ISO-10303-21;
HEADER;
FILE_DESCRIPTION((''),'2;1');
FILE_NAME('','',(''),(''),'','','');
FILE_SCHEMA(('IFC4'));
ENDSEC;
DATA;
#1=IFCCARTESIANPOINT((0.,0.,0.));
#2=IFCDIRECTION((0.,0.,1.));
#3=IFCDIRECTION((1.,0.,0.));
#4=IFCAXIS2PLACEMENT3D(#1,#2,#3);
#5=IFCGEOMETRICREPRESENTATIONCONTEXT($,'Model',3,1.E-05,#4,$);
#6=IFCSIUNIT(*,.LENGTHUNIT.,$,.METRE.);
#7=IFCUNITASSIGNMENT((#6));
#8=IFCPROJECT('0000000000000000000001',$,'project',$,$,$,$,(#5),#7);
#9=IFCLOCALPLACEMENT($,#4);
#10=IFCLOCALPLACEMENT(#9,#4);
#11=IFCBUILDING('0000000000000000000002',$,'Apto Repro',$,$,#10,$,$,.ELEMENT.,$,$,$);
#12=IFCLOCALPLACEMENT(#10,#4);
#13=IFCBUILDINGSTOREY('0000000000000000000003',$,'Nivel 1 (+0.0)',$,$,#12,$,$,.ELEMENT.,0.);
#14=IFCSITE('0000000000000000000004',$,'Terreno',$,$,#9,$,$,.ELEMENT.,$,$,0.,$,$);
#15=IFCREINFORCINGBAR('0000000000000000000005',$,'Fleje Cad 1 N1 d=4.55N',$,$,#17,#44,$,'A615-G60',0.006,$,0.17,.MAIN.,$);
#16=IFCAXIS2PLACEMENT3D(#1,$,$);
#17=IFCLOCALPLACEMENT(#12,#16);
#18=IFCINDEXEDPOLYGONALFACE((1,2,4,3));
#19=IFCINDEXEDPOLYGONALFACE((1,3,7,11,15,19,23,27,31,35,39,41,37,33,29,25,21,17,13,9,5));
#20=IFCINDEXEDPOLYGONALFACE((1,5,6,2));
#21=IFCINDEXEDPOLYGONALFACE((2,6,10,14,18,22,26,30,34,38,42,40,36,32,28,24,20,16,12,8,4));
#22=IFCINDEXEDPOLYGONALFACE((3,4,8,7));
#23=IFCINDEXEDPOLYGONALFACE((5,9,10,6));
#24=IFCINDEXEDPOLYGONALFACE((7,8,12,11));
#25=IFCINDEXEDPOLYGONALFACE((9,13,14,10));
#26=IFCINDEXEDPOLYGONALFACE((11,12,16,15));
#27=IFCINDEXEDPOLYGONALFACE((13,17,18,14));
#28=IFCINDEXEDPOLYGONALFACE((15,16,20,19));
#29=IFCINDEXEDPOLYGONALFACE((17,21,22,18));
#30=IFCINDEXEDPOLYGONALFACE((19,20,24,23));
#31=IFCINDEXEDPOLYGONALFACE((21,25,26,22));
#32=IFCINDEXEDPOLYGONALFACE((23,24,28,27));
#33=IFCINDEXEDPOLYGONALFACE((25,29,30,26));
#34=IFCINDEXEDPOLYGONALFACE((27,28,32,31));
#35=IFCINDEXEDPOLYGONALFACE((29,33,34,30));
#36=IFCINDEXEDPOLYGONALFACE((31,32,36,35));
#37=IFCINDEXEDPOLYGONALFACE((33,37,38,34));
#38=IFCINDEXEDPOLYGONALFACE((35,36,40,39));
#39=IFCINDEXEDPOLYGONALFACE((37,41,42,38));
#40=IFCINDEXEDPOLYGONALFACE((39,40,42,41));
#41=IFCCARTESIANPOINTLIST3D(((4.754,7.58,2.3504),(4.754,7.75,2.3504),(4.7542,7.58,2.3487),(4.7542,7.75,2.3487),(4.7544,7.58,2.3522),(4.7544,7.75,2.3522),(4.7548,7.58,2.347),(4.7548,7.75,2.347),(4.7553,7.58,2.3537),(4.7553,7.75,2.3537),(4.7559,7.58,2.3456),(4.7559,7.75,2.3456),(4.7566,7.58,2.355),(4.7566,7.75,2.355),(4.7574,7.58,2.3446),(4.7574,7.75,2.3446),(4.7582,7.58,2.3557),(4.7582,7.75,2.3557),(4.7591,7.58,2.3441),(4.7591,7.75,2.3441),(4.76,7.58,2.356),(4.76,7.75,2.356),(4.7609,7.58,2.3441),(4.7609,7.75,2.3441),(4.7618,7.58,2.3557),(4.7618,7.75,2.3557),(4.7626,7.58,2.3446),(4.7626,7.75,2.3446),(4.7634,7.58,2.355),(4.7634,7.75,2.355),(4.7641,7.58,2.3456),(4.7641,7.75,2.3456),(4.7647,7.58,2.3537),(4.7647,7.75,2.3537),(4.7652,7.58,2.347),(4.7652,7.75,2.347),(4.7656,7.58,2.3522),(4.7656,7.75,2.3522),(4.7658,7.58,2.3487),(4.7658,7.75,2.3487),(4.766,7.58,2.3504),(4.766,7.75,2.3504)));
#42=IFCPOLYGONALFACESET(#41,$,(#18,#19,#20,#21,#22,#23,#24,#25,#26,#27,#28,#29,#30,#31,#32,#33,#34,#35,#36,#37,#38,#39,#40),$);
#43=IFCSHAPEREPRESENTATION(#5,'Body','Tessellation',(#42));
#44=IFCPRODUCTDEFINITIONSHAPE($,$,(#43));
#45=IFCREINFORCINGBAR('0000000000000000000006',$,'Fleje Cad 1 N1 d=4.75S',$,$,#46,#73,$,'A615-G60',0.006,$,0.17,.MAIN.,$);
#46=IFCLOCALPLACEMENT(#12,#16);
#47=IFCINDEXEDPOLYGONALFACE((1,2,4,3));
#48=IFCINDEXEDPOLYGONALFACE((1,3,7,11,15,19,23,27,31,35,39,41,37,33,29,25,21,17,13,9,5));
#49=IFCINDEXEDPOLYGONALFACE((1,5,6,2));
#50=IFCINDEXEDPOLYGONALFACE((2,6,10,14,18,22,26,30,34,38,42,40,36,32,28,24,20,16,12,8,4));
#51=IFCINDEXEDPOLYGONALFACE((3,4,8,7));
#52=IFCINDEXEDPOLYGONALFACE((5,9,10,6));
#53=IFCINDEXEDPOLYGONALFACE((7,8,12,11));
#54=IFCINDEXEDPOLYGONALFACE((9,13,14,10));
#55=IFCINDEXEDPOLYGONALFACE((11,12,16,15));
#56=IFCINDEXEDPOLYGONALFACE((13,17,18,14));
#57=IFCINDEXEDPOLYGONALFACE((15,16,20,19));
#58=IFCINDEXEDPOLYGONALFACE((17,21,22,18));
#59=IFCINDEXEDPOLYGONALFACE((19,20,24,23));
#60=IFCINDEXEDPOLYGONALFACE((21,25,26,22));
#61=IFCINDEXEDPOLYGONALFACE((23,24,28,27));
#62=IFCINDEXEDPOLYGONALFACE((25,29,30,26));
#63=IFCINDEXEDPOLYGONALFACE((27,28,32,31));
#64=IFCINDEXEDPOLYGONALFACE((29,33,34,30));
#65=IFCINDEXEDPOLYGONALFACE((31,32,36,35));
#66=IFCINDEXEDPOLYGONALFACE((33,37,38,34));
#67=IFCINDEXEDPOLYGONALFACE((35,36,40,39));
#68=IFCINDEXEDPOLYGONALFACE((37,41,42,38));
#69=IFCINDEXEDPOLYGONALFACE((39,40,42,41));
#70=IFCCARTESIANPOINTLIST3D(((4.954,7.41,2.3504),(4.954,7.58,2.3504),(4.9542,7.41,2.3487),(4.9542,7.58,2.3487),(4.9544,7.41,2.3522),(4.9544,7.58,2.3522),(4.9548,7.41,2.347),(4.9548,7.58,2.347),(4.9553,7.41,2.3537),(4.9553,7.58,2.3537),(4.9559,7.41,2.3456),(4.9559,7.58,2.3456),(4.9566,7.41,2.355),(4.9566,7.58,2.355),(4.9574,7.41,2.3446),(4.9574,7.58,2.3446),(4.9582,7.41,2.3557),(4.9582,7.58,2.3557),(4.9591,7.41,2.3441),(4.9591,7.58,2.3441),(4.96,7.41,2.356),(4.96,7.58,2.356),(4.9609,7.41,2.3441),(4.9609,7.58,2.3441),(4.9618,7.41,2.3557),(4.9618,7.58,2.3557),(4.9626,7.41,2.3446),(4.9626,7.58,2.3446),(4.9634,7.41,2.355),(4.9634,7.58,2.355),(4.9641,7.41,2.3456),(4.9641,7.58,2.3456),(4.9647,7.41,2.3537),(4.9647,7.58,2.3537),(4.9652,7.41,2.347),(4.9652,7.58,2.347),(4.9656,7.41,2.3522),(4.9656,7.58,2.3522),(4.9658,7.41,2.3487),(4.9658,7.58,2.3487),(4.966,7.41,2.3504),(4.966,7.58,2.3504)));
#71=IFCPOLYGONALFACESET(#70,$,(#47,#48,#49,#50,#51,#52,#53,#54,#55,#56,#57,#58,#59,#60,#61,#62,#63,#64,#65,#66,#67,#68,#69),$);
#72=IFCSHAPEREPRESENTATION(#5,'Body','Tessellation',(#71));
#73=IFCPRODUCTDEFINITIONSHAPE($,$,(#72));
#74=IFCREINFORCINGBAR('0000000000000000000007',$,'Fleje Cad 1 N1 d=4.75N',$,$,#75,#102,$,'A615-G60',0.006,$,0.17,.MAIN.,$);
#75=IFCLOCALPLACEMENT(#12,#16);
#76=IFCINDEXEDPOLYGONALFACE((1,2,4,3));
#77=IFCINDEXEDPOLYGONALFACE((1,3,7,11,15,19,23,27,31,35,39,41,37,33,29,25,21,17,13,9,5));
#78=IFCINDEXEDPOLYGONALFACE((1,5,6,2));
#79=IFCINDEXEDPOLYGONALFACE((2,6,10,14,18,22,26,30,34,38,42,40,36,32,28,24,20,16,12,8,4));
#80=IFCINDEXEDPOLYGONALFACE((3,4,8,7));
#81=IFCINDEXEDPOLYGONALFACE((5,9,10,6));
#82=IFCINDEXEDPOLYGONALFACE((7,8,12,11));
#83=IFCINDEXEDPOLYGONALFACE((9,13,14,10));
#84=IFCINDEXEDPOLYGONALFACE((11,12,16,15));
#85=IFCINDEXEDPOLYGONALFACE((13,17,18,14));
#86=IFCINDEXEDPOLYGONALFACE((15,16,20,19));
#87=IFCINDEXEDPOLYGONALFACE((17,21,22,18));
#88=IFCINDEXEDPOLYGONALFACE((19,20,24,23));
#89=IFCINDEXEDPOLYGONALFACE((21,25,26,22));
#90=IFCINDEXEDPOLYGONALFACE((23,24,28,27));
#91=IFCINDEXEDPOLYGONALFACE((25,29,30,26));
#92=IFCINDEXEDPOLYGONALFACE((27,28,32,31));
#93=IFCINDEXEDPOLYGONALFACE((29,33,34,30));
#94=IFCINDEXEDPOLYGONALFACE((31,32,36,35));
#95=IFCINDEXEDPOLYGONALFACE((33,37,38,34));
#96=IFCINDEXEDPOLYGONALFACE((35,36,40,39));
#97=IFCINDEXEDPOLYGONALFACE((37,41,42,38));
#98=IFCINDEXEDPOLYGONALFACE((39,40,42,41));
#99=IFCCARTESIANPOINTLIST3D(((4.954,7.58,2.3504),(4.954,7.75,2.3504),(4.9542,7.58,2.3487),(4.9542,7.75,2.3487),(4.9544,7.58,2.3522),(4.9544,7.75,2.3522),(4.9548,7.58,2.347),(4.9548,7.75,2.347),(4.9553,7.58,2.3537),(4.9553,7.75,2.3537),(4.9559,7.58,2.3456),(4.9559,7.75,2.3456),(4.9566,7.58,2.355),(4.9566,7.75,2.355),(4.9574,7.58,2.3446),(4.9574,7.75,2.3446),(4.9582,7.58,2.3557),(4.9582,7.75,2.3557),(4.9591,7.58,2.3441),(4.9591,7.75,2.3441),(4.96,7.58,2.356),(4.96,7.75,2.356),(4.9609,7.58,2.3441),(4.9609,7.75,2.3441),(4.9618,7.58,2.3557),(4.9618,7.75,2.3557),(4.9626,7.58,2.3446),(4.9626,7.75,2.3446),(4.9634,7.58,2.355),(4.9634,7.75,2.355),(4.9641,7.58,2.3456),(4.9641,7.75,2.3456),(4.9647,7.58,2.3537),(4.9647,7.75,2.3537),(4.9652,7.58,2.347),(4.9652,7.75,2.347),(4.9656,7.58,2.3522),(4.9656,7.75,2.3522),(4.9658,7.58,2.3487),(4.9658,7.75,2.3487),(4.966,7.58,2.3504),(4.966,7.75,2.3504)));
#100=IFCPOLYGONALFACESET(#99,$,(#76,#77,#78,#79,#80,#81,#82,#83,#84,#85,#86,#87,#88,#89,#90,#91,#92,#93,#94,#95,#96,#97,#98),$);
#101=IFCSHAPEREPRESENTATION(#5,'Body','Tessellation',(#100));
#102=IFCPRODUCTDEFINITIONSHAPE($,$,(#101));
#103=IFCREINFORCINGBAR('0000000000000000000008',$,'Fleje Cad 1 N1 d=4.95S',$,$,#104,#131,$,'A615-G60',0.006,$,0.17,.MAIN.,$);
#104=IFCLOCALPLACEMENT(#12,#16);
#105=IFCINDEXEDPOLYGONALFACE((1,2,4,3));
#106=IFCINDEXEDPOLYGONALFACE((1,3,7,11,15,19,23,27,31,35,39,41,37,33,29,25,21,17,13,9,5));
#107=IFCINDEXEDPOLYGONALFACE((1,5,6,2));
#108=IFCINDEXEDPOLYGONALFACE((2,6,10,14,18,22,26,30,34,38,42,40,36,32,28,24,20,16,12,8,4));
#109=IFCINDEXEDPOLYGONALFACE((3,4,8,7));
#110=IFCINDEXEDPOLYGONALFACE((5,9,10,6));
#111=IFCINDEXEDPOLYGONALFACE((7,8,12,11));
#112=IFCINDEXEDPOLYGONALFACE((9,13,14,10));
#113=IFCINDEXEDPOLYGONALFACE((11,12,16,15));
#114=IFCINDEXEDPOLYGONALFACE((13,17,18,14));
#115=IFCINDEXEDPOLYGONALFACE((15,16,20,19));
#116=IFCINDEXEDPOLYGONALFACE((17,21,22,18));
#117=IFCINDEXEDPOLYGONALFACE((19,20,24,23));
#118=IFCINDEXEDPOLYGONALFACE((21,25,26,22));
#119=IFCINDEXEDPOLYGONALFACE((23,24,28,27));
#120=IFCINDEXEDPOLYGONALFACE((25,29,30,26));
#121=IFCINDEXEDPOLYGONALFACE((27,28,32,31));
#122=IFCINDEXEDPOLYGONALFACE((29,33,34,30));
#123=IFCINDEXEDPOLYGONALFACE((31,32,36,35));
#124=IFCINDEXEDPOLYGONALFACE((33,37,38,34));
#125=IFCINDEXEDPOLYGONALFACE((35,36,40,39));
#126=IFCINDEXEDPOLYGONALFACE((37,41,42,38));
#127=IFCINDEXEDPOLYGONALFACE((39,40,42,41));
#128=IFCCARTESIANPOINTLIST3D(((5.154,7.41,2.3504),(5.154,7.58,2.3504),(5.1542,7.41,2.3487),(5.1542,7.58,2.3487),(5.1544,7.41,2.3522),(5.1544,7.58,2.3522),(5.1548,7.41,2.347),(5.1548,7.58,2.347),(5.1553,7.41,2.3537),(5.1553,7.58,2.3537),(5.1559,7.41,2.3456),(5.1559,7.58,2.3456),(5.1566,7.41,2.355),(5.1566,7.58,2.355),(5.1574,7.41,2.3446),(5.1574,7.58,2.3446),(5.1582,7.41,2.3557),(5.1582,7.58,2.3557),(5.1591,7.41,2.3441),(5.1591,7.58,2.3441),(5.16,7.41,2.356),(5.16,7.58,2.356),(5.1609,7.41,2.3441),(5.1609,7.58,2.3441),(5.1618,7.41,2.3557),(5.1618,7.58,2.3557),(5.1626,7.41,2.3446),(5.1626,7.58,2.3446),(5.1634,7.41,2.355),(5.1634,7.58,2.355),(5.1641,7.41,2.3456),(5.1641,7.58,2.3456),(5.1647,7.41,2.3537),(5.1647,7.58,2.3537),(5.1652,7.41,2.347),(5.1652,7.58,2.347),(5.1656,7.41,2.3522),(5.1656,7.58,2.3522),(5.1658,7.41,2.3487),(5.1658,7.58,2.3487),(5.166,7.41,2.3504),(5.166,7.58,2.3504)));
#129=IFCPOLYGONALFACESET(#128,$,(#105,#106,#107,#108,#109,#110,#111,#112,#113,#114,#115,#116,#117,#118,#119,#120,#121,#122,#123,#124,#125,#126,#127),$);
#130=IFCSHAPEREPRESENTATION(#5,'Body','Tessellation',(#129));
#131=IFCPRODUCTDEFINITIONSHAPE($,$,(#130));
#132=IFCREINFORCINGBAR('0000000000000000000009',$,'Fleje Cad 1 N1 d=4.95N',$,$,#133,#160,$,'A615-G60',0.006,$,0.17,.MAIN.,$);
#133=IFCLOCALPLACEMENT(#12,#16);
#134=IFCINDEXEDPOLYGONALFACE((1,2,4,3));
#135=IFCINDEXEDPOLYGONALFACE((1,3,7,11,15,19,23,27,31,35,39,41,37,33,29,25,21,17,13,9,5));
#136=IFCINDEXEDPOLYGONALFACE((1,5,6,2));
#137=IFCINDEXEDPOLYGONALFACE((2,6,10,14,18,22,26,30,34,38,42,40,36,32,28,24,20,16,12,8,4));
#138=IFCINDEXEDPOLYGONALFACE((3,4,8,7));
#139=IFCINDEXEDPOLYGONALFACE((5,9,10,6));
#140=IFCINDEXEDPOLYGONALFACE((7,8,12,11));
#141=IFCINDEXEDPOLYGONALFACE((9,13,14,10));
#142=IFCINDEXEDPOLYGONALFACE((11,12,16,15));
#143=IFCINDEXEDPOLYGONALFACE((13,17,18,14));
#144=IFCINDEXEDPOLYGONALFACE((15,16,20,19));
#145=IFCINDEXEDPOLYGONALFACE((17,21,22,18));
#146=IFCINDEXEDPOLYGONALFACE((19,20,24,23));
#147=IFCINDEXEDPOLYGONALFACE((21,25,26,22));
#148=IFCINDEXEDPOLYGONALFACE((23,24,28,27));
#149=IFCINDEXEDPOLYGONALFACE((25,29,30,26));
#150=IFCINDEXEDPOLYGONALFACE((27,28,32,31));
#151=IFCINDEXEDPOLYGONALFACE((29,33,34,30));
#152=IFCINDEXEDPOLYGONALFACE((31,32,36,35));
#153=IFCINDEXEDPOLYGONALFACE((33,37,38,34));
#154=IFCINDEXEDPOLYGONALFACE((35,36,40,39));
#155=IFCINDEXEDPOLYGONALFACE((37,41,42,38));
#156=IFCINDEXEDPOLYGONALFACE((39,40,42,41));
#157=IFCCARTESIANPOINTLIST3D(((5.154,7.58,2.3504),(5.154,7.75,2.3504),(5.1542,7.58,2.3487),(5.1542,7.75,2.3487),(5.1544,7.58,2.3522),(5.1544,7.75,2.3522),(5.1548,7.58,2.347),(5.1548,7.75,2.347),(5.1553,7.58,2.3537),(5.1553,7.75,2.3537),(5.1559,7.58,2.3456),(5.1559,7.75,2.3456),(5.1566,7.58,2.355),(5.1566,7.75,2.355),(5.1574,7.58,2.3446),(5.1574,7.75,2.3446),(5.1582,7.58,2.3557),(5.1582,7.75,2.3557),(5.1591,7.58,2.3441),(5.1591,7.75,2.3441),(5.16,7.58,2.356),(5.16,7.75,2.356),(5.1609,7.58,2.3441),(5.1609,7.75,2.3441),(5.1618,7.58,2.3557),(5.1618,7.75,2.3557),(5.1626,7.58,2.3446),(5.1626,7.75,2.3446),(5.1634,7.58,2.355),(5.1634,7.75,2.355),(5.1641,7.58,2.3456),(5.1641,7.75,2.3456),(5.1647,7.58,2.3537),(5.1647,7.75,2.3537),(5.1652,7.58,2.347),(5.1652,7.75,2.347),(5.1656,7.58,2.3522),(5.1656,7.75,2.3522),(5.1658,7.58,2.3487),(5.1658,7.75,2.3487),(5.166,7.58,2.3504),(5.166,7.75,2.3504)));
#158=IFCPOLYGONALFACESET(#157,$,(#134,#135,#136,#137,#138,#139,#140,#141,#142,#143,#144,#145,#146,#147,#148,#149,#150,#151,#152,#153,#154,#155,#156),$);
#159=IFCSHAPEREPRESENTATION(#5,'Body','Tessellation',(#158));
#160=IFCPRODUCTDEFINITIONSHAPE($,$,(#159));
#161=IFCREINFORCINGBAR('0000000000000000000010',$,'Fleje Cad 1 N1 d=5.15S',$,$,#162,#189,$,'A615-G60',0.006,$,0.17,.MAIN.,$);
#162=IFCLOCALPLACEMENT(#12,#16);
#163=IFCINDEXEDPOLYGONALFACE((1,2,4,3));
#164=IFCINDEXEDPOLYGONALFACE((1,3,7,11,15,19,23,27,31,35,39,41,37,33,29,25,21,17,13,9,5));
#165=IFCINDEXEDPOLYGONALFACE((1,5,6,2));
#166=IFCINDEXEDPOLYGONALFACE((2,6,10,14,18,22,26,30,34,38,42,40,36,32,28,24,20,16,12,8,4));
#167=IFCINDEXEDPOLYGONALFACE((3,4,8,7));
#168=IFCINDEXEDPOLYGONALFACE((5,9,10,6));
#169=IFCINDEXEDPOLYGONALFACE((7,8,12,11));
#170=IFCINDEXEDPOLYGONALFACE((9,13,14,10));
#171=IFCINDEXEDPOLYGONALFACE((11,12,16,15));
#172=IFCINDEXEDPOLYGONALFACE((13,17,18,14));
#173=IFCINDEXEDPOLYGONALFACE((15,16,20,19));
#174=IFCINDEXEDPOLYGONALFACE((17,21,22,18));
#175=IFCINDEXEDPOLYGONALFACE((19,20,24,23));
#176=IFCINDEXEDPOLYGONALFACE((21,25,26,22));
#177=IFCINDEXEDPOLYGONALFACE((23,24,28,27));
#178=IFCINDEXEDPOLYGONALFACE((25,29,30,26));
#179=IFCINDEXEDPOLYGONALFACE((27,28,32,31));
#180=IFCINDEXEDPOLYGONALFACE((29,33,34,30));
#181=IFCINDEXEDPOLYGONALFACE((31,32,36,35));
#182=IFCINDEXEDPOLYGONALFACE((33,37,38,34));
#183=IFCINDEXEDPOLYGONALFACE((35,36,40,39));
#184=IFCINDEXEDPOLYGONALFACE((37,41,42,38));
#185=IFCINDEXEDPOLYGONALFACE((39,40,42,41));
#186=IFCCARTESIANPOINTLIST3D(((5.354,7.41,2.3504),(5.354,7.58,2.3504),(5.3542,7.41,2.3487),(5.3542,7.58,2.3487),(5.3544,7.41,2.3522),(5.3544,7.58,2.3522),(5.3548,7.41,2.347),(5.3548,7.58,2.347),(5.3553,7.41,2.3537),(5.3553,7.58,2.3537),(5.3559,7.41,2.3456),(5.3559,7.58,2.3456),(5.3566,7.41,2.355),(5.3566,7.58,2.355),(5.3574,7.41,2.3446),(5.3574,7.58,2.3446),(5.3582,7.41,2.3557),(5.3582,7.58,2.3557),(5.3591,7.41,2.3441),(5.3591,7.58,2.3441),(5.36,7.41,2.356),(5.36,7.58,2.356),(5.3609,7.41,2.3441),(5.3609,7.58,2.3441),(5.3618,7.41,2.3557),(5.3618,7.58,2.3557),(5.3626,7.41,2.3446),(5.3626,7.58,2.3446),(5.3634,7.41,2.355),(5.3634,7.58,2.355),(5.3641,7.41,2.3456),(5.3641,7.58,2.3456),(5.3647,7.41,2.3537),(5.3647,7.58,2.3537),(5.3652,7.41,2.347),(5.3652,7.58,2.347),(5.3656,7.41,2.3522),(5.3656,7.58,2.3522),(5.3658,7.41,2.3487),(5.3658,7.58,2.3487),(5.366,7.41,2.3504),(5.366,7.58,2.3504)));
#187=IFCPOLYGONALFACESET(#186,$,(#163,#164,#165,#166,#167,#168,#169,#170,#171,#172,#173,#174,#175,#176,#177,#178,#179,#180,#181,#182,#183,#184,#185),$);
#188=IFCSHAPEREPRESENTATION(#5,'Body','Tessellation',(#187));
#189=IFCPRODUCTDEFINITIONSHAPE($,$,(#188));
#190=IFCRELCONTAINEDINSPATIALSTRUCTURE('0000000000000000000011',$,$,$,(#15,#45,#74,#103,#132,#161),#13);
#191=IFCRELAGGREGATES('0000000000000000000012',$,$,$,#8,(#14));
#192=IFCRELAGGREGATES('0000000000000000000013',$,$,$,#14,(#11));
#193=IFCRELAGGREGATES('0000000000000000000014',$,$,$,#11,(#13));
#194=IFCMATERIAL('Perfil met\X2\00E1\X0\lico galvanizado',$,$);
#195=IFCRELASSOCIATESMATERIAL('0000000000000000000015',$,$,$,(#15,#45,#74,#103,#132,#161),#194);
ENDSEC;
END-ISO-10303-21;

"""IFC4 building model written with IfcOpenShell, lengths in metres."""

from ifc_helpers import new_model, si_unit, frame, origin_with_axes, origin_2d_with_axis, place, context, project, spatial, circle, extrude, material, element, save


model = new_model("IFC4")

# Units and contexts
model_context = context("Model", 3, precision=1e-05, world=origin_with_axes())
ifc_project = project(units=[si_unit("LENGTHUNIT", "METRE")], contexts=[model_context])

# Site, building, storey
site_placement = place(None, origin_with_axes())
site = spatial("IfcSite", under=ifc_project, at=site_placement, Name="Terreno", CompositionType="ELEMENT", RefElevation=0.0)
building_placement = place(site_placement, origin_with_axes())
building = spatial("IfcBuilding", under=site, at=building_placement, Name="Apto Repro", CompositionType="ELEMENT")
storey_placement = place(building_placement, origin_with_axes())
storey = spatial("IfcBuildingStorey", under=building, at=storey_placement, Name="Nivel 1 (+0.0)", CompositionType="ELEMENT", Elevation=0.0)

# Reinforcing bars
ifc_material = material(Name="Perfil metálico galvanizado")
reinforcing_bar_1_placement = place(storey_placement, origin_with_axes())
element("IfcReinforcingBar", 1, at=reinforcing_bar_1_placement, inside=storey, material=ifc_material, Name="Fleje Cad 1 N1 d=4.55N", SteelGrade="A615-G60", BarLength=0.17, NominalDiameter=0.006, PredefinedType="MAIN", context=model_context, shape_type="SweptSolid", body=[
    extrude(circle(Radius=0.006, at=origin_2d_with_axis()), frame((4.76, 7.58, 2.35), z_axis=(0.0, 1.0, 0.0), x_axis=(0.0, 0.0, 1.0)), (0.0, 0.0, 1.0), 0.17),
])
reinforcing_bar_2_placement = place(storey_placement, origin_with_axes())
element("IfcReinforcingBar", 2, at=reinforcing_bar_2_placement, inside=storey, material=ifc_material, Name="Fleje Cad 1 N1 d=4.75S", SteelGrade="A615-G60", BarLength=0.17, NominalDiameter=0.006, PredefinedType="MAIN", context=model_context, shape_type="SweptSolid", body=[
    extrude(circle(Radius=0.006, at=origin_2d_with_axis()), frame((4.96, 7.41, 2.35), z_axis=(0.0, 1.0, 0.0), x_axis=(0.0, 0.0, 1.0)), (0.0, 0.0, 1.0), 0.17),
])
reinforcing_bar_3_placement = place(storey_placement, origin_with_axes())
element("IfcReinforcingBar", 3, at=reinforcing_bar_3_placement, inside=storey, material=ifc_material, Name="Fleje Cad 1 N1 d=4.75N", SteelGrade="A615-G60", BarLength=0.17, NominalDiameter=0.006, PredefinedType="MAIN", context=model_context, shape_type="SweptSolid", body=[
    extrude(circle(Radius=0.006, at=origin_2d_with_axis()), frame((4.96, 7.58, 2.35), z_axis=(0.0, 1.0, 0.0), x_axis=(0.0, 0.0, 1.0)), (0.0, 0.0, 1.0), 0.17),
])
reinforcing_bar_4_placement = place(storey_placement, origin_with_axes())
element("IfcReinforcingBar", 4, at=reinforcing_bar_4_placement, inside=storey, material=ifc_material, Name="Fleje Cad 1 N1 d=4.95S", SteelGrade="A615-G60", BarLength=0.17, NominalDiameter=0.006, PredefinedType="MAIN", context=model_context, shape_type="SweptSolid", body=[
    extrude(circle(Radius=0.006, at=origin_2d_with_axis()), frame((5.16, 7.41, 2.35), z_axis=(0.0, 1.0, 0.0), x_axis=(0.0, 0.0, 1.0)), (0.0, 0.0, 1.0), 0.17),
])
reinforcing_bar_5_placement = place(storey_placement, origin_with_axes())
element("IfcReinforcingBar", 5, at=reinforcing_bar_5_placement, inside=storey, material=ifc_material, Name="Fleje Cad 1 N1 d=4.95N", SteelGrade="A615-G60", BarLength=0.17, NominalDiameter=0.006, PredefinedType="MAIN", context=model_context, shape_type="SweptSolid", body=[
    extrude(circle(Radius=0.006, at=origin_2d_with_axis()), frame((5.16, 7.58, 2.35), z_axis=(0.0, 1.0, 0.0), x_axis=(0.0, 0.0, 1.0)), (0.0, 0.0, 1.0), 0.17),
])
reinforcing_bar_6_placement = place(storey_placement, origin_with_axes())
element("IfcReinforcingBar", 6, at=reinforcing_bar_6_placement, inside=storey, material=ifc_material, Name="Fleje Cad 1 N1 d=5.15S", SteelGrade="A615-G60", BarLength=0.17, NominalDiameter=0.006, PredefinedType="MAIN", context=model_context, shape_type="SweptSolid", body=[
    extrude(circle(Radius=0.006, at=origin_2d_with_axis()), frame((5.36, 7.41, 2.35), z_axis=(0.0, 1.0, 0.0), x_axis=(0.0, 0.0, 1.0)), (0.0, 0.0, 1.0), 0.17),
])

save(model, "model.ifc")
